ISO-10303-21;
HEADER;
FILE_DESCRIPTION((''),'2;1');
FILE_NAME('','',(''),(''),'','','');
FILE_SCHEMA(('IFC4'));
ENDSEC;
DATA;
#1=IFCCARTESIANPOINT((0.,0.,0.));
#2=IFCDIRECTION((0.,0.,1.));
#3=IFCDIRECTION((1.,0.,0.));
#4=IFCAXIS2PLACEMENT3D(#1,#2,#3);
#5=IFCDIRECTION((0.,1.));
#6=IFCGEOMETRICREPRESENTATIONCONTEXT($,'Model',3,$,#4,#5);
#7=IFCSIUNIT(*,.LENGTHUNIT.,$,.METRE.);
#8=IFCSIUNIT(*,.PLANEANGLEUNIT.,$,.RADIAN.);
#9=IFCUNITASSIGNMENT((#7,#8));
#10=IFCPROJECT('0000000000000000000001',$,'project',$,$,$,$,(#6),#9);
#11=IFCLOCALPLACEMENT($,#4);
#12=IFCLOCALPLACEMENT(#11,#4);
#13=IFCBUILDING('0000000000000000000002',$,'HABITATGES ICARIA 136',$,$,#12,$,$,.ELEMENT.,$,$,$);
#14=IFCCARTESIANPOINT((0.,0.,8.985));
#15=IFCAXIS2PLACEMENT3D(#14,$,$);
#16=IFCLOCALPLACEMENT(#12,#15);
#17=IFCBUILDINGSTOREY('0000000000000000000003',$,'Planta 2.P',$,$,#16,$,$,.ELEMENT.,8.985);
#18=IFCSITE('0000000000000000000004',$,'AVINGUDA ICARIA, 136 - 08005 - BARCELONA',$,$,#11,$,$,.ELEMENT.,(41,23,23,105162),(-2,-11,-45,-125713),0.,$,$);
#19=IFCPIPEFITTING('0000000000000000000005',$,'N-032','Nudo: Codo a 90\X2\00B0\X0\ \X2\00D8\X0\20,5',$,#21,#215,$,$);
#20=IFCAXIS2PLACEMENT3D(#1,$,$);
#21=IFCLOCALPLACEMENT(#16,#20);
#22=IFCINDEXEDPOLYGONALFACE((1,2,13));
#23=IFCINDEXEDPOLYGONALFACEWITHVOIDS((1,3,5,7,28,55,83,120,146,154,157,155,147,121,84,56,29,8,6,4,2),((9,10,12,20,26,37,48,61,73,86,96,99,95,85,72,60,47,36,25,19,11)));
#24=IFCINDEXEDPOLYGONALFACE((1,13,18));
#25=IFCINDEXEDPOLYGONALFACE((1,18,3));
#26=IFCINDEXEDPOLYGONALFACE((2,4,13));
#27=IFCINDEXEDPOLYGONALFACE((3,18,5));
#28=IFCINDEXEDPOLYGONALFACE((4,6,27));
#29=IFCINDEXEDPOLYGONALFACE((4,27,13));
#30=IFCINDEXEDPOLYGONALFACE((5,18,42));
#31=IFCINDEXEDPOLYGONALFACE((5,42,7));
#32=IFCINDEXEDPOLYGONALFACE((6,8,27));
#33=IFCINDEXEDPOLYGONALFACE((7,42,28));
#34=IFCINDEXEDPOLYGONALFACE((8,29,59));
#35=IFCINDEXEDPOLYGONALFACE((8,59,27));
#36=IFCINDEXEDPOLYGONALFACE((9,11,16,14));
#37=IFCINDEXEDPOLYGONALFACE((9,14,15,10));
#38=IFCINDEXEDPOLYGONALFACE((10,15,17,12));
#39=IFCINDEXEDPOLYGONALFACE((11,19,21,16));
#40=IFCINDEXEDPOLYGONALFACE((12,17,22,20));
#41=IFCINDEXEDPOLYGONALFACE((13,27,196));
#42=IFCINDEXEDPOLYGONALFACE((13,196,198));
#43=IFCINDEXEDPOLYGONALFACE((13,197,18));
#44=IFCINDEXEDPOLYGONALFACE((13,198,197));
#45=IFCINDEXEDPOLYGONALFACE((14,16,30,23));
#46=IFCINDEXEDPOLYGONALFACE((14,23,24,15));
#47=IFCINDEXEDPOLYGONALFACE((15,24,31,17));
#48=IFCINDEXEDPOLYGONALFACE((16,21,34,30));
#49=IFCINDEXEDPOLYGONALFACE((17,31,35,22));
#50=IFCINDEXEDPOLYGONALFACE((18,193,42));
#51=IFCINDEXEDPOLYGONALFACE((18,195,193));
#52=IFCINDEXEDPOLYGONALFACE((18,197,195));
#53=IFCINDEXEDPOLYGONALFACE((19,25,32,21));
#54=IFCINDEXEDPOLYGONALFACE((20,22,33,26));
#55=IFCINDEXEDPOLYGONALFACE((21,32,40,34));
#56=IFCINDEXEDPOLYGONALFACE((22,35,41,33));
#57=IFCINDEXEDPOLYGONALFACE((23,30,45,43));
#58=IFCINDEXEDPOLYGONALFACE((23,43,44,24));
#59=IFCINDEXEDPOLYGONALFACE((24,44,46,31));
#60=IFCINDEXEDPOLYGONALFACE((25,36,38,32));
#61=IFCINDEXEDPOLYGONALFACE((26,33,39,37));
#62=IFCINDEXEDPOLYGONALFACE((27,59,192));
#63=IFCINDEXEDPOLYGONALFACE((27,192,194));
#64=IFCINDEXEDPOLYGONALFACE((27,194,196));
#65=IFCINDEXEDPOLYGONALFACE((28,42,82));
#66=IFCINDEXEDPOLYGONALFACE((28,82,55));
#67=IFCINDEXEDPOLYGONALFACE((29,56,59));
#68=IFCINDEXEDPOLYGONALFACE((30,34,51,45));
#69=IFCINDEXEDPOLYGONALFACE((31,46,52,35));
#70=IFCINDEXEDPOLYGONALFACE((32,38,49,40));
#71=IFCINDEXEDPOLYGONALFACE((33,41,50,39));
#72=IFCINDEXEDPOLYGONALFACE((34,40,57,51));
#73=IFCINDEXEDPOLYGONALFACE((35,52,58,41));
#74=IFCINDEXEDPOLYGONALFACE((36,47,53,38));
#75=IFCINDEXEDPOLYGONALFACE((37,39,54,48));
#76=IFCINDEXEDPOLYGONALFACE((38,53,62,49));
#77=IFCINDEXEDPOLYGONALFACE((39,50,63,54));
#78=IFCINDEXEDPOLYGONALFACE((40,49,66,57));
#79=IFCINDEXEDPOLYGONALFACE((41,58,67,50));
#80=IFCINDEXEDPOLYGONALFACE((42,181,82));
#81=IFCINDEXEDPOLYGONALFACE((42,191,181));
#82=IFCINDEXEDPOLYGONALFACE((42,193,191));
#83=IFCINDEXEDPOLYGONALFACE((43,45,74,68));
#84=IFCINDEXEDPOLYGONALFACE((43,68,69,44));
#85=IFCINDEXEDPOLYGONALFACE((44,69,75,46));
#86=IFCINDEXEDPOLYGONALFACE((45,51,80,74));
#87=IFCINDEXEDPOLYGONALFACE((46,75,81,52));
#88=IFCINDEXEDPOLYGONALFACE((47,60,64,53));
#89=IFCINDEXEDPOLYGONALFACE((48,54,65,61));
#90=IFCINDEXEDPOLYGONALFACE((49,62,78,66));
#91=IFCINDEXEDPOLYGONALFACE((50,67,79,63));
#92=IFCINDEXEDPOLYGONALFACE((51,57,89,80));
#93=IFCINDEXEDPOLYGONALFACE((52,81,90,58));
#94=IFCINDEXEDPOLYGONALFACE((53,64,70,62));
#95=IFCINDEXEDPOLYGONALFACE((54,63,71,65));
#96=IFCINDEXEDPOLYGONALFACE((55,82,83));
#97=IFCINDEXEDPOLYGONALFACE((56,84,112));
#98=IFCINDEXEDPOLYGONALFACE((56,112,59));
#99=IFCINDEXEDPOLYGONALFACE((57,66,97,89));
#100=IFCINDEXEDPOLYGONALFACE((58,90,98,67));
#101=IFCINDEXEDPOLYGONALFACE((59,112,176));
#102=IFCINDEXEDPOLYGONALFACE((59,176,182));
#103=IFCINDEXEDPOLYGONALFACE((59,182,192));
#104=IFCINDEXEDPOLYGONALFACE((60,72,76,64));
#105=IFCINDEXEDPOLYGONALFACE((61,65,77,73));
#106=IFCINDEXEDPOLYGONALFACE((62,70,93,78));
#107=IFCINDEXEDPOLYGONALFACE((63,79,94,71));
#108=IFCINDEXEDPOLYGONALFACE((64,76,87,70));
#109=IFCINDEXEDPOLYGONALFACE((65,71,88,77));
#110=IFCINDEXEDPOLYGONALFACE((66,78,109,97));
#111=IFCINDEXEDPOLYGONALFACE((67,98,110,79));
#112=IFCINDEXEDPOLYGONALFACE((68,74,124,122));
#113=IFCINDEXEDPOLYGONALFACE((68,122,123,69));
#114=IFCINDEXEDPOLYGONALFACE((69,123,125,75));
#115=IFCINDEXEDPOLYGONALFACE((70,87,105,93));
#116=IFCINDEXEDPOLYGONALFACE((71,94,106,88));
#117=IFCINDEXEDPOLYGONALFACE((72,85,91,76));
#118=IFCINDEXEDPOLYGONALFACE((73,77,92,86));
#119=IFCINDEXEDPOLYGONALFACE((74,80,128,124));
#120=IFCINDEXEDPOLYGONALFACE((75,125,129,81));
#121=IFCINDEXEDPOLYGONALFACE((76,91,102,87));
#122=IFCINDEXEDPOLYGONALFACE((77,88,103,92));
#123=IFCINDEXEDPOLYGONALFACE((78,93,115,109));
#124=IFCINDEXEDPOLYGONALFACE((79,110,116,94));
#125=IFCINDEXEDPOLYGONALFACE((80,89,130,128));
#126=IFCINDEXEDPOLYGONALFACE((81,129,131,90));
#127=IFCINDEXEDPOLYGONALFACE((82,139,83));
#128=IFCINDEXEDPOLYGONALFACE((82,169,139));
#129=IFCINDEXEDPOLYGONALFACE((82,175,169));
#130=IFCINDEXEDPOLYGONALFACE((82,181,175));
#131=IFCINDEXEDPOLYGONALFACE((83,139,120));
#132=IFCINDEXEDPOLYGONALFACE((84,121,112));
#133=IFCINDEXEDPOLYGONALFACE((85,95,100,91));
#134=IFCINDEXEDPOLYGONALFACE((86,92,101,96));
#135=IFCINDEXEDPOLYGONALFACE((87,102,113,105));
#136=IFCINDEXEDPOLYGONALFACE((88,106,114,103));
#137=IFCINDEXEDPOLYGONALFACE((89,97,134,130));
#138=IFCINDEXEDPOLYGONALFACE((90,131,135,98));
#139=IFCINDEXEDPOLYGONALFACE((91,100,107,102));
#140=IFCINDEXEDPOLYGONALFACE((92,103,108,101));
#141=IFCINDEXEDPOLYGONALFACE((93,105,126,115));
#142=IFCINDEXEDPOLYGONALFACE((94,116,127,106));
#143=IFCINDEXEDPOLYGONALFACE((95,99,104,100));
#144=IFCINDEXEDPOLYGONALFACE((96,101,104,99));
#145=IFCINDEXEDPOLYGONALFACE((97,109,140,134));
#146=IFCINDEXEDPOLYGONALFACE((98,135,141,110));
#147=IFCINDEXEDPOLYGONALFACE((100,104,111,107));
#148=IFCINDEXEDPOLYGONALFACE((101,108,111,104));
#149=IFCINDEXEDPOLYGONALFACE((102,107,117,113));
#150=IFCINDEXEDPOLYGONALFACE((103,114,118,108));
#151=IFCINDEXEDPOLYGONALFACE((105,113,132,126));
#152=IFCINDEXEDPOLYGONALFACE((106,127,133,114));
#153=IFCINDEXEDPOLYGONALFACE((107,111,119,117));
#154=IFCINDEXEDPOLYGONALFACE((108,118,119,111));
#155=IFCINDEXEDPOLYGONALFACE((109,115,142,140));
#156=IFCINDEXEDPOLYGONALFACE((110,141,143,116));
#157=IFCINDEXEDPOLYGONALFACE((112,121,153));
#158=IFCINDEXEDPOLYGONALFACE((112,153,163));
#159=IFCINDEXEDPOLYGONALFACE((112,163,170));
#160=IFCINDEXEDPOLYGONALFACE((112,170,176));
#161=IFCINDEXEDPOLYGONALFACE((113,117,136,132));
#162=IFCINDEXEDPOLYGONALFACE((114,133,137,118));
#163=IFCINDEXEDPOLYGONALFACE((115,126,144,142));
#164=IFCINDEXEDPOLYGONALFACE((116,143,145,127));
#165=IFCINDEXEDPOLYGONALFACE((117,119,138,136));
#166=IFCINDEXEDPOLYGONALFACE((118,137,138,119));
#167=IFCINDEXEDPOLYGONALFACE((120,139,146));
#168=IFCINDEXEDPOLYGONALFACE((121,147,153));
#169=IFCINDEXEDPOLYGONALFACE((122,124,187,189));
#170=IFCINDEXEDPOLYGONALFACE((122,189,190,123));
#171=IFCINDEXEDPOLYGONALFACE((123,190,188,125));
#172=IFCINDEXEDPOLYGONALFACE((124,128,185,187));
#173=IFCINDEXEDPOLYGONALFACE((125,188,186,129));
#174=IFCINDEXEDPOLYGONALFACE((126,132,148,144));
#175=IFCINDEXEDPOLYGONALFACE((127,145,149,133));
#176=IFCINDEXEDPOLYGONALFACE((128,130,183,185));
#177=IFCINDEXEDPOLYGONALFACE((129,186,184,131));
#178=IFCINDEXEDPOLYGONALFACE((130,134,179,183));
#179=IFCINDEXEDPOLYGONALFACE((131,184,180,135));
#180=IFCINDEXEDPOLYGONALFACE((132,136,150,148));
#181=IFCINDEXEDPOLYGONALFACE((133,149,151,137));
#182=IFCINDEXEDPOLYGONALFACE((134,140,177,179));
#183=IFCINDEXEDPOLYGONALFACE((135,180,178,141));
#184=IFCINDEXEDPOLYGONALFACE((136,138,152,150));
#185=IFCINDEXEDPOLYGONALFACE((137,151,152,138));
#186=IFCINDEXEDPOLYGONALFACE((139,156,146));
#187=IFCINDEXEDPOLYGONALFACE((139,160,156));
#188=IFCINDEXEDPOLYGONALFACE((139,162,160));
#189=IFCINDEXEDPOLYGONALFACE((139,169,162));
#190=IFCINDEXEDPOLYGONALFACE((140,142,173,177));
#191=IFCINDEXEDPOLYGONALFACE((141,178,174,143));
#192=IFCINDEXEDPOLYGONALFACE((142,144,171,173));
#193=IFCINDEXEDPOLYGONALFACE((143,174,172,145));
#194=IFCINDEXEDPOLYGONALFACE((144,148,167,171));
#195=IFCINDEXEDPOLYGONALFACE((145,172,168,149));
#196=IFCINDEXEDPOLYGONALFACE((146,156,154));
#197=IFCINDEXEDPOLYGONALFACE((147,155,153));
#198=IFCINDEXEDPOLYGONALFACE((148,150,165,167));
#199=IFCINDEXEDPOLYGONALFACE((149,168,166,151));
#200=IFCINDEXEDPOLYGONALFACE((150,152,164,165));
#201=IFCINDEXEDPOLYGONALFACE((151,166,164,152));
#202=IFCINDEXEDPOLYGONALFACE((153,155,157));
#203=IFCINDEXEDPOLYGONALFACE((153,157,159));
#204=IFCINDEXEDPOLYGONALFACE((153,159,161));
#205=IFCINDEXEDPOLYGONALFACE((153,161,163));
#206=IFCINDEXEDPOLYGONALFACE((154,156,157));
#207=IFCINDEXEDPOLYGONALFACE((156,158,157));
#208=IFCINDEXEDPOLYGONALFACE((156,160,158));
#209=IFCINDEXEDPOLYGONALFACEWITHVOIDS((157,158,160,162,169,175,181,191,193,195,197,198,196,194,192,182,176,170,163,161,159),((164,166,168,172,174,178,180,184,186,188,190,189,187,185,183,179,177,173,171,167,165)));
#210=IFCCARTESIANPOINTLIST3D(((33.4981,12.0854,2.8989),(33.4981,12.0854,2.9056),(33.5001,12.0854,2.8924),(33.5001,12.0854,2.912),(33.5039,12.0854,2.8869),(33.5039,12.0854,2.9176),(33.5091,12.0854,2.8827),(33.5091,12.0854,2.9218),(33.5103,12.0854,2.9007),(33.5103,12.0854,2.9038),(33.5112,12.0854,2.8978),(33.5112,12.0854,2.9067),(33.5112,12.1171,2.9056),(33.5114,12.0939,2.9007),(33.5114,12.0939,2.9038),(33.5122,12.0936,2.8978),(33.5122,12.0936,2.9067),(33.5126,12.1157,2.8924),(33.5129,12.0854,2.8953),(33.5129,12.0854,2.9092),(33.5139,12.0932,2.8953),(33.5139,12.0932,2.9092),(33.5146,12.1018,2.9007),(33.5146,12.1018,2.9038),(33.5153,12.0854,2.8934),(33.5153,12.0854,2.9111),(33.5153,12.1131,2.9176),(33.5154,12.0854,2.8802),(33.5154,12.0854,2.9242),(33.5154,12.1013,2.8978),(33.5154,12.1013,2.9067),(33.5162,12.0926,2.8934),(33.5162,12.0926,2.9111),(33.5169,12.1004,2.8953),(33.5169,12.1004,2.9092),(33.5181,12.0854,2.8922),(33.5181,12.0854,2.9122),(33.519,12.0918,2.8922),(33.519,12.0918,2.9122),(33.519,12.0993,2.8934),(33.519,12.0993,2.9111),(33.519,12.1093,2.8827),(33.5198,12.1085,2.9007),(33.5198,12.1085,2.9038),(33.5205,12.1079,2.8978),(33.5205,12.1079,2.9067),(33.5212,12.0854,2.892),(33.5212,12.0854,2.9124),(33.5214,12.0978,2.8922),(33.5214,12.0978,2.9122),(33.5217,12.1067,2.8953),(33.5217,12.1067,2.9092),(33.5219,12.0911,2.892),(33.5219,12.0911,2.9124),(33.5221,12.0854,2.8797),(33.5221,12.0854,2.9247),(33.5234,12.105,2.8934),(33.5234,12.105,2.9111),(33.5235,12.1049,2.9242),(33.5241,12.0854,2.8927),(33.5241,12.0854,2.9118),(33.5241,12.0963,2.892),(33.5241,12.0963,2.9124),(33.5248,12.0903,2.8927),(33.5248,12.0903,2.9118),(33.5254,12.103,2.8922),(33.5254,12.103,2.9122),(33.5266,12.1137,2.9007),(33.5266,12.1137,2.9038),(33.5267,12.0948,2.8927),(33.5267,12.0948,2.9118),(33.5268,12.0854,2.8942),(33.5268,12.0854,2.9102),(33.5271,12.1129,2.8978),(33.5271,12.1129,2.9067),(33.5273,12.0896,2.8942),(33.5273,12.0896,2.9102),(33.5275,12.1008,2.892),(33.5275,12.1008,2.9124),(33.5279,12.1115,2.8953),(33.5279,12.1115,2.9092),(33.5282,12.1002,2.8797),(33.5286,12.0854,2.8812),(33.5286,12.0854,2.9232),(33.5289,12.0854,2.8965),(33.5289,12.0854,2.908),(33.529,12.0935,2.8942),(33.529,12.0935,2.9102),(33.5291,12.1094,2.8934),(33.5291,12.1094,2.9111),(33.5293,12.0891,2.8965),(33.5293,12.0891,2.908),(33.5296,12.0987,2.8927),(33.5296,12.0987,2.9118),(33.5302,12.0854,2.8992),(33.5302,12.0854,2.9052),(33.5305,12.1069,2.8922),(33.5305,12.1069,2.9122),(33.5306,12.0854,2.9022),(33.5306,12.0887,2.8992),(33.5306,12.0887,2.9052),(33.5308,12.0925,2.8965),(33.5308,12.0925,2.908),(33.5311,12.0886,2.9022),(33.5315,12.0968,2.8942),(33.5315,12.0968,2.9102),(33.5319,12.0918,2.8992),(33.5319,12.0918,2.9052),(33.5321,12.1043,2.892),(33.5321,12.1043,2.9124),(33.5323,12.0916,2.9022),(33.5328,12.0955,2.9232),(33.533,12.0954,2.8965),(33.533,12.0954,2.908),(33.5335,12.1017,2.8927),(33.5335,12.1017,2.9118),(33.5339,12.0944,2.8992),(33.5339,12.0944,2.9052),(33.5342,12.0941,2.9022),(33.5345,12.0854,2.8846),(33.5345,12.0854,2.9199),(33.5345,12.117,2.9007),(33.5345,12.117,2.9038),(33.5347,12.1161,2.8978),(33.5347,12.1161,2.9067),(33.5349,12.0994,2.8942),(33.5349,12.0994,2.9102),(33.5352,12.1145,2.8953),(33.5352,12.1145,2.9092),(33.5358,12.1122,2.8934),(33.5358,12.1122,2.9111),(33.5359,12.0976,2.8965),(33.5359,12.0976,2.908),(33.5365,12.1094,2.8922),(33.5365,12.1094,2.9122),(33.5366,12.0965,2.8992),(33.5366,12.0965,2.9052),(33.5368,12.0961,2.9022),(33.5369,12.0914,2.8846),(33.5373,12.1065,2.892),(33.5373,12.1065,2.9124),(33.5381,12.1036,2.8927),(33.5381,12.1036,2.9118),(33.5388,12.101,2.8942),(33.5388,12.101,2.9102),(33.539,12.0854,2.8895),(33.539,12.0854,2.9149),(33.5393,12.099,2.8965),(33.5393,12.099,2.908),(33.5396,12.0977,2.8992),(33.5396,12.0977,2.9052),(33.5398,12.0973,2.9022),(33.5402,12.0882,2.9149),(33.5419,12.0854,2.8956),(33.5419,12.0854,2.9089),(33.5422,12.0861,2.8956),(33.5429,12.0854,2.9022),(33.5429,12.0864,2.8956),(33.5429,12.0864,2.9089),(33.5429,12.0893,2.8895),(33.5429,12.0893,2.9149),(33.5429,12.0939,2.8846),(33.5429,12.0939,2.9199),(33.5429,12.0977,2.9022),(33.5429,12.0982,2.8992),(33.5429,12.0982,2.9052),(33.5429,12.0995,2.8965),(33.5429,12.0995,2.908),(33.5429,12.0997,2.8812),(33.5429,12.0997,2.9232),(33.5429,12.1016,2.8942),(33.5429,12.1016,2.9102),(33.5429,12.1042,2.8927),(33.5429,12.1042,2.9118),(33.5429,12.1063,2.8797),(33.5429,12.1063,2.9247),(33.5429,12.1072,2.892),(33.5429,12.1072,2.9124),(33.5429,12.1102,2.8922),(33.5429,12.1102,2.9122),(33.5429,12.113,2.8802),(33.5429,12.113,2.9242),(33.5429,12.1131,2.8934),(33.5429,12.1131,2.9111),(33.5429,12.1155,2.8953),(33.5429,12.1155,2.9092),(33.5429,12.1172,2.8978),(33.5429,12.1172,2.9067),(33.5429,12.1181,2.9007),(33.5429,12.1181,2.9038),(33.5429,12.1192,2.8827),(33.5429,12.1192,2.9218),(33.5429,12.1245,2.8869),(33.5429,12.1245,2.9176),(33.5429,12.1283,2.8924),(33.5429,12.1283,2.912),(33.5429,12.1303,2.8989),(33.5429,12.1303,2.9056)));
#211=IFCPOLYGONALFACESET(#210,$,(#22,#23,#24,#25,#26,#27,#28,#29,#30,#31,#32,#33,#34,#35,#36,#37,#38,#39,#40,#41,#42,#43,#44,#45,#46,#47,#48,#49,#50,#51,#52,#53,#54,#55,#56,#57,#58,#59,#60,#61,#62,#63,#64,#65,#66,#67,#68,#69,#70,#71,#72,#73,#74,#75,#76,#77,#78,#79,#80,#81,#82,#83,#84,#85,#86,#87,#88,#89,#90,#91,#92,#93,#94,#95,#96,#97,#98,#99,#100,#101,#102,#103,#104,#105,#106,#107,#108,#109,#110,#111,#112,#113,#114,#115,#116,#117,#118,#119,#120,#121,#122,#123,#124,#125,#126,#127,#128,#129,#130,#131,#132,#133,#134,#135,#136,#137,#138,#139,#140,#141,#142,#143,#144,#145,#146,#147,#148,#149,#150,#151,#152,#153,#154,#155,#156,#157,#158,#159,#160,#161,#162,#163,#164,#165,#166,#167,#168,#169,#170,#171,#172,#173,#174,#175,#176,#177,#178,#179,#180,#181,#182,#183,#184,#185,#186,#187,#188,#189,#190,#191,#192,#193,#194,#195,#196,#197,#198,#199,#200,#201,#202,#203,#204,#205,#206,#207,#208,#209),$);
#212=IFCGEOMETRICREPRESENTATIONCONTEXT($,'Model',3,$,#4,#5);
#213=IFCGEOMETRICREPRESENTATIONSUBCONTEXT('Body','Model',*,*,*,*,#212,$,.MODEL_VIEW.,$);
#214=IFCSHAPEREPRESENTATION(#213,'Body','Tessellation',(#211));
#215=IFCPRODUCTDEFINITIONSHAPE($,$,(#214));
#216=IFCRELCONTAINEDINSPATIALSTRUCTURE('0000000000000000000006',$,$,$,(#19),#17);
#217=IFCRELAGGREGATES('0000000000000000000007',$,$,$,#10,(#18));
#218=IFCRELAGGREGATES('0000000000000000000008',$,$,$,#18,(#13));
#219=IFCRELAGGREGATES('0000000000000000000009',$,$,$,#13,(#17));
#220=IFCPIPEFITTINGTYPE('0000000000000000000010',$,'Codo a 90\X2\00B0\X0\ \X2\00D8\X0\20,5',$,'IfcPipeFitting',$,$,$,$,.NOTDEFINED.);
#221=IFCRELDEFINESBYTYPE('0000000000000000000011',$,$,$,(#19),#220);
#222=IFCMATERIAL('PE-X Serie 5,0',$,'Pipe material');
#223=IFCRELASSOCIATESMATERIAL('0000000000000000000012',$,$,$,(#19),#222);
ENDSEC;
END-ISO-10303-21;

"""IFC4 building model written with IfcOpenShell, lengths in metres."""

from ifc_helpers import new_model, entity, si_unit, direction, frame, origin_with_axes, place, context, subcontext, project, spatial, source, transform, mapped, material, type_object, element, save


model = new_model("IFC4")

# Units and contexts
model_context_1 = context("Model", 3, world=origin_with_axes(), true_north=direction((0.0, 1.0)))
model_context_2 = context("Model", 3, world=origin_with_axes(), true_north=direction((0.0, 1.0)))
body_context_1 = subcontext(model_context_2, "Body", "Model", "MODEL_VIEW")
ifc_project = project(units=[si_unit("LENGTHUNIT", "METRE"), si_unit("PLANEANGLEUNIT", "RADIAN")], contexts=[model_context_1])

# Site, building, storey
site_placement = place(None, origin_with_axes())
site = spatial("IfcSite", under=ifc_project, at=site_placement, Name="AVINGUDA ICARIA, 136 - 08005 - BARCELONA", CompositionType="ELEMENT", RefLatitude=(41, 23, 23, 105162), RefLongitude=(-2, -11, -45, -125713), RefElevation=0.0)
building_placement = place(site_placement, origin_with_axes())
building = spatial("IfcBuilding", under=site, at=building_placement, Name="HABITATGES ICARIA 136", CompositionType="ELEMENT")
storey_placement = place(building_placement, frame((0.0, 0.0, 8.985)))
storey = spatial("IfcBuildingStorey", under=building, at=storey_placement, Name="Planta 2.P", CompositionType="ELEMENT", Elevation=8.985)

# Shared definitions
ifc_material_1 = material(Name="PE-X Serie 5,0", Category="Pipe material")
placement_1 = place(None, origin_with_axes())
placement_2 = place(placement_1, origin_with_axes())
placement_3 = place(placement_2, frame((0.0, 0.0, 8.985)))

# Pipe fitting
pipe_fitting_type_1 = type_object("IfcPipeFittingType", Name="Codo a 90° Ø20,5", ApplicableOccurrence="IfcPipeFitting", PredefinedType="NOTDEFINED")
shared_shape_1 = source(origin_with_axes(), body_context_1, "Body", "SweptSolid", [
    entity("IfcRevolvedAreaSolid", entity("IfcCircleHollowProfileDef", "AREA", None, entity("IfcAxis2Placement2D", entity("IfcCartesianPoint", [0.0, 0.0]), entity("IfcDirection", [1.0, 0.0])), 0.0226, 0.0123), entity("IfcAxis2Placement3D", entity("IfcCartesianPoint", [0.0226, 0.0, 0.0]), entity("IfcDirection", [-1.0, 0.0, 0.0]), entity("IfcDirection", [0.0, -1.0, 0.0])), entity("IfcAxis1Placement", entity("IfcCartesianPoint", [0.0226, 0.0, 0.0]), entity("IfcDirection", [0.0, 1.0, 0.0])), 1.570796),
])
pipe_fitting_1_placement = place(placement_3, origin_with_axes())
element("IfcPipeFitting", 1, at=pipe_fitting_1_placement, inside=storey, type_object=pipe_fitting_type_1, material=ifc_material_1, Name="N-032", Description="Nudo: Codo a 90° Ø20,5", context=body_context_1, shape_type="MappedRepresentation", body=[
    mapped(shared_shape_1, transform((33.5204, 12.108, 2.9022), x_axis=(1.0, 0.0, 0.0), y_axis=(0.0, 1.0, 0.0), z_axis=(0.0, 0.0, 1.0), scale=1.0)),
])

save(model, "model.ifc")
